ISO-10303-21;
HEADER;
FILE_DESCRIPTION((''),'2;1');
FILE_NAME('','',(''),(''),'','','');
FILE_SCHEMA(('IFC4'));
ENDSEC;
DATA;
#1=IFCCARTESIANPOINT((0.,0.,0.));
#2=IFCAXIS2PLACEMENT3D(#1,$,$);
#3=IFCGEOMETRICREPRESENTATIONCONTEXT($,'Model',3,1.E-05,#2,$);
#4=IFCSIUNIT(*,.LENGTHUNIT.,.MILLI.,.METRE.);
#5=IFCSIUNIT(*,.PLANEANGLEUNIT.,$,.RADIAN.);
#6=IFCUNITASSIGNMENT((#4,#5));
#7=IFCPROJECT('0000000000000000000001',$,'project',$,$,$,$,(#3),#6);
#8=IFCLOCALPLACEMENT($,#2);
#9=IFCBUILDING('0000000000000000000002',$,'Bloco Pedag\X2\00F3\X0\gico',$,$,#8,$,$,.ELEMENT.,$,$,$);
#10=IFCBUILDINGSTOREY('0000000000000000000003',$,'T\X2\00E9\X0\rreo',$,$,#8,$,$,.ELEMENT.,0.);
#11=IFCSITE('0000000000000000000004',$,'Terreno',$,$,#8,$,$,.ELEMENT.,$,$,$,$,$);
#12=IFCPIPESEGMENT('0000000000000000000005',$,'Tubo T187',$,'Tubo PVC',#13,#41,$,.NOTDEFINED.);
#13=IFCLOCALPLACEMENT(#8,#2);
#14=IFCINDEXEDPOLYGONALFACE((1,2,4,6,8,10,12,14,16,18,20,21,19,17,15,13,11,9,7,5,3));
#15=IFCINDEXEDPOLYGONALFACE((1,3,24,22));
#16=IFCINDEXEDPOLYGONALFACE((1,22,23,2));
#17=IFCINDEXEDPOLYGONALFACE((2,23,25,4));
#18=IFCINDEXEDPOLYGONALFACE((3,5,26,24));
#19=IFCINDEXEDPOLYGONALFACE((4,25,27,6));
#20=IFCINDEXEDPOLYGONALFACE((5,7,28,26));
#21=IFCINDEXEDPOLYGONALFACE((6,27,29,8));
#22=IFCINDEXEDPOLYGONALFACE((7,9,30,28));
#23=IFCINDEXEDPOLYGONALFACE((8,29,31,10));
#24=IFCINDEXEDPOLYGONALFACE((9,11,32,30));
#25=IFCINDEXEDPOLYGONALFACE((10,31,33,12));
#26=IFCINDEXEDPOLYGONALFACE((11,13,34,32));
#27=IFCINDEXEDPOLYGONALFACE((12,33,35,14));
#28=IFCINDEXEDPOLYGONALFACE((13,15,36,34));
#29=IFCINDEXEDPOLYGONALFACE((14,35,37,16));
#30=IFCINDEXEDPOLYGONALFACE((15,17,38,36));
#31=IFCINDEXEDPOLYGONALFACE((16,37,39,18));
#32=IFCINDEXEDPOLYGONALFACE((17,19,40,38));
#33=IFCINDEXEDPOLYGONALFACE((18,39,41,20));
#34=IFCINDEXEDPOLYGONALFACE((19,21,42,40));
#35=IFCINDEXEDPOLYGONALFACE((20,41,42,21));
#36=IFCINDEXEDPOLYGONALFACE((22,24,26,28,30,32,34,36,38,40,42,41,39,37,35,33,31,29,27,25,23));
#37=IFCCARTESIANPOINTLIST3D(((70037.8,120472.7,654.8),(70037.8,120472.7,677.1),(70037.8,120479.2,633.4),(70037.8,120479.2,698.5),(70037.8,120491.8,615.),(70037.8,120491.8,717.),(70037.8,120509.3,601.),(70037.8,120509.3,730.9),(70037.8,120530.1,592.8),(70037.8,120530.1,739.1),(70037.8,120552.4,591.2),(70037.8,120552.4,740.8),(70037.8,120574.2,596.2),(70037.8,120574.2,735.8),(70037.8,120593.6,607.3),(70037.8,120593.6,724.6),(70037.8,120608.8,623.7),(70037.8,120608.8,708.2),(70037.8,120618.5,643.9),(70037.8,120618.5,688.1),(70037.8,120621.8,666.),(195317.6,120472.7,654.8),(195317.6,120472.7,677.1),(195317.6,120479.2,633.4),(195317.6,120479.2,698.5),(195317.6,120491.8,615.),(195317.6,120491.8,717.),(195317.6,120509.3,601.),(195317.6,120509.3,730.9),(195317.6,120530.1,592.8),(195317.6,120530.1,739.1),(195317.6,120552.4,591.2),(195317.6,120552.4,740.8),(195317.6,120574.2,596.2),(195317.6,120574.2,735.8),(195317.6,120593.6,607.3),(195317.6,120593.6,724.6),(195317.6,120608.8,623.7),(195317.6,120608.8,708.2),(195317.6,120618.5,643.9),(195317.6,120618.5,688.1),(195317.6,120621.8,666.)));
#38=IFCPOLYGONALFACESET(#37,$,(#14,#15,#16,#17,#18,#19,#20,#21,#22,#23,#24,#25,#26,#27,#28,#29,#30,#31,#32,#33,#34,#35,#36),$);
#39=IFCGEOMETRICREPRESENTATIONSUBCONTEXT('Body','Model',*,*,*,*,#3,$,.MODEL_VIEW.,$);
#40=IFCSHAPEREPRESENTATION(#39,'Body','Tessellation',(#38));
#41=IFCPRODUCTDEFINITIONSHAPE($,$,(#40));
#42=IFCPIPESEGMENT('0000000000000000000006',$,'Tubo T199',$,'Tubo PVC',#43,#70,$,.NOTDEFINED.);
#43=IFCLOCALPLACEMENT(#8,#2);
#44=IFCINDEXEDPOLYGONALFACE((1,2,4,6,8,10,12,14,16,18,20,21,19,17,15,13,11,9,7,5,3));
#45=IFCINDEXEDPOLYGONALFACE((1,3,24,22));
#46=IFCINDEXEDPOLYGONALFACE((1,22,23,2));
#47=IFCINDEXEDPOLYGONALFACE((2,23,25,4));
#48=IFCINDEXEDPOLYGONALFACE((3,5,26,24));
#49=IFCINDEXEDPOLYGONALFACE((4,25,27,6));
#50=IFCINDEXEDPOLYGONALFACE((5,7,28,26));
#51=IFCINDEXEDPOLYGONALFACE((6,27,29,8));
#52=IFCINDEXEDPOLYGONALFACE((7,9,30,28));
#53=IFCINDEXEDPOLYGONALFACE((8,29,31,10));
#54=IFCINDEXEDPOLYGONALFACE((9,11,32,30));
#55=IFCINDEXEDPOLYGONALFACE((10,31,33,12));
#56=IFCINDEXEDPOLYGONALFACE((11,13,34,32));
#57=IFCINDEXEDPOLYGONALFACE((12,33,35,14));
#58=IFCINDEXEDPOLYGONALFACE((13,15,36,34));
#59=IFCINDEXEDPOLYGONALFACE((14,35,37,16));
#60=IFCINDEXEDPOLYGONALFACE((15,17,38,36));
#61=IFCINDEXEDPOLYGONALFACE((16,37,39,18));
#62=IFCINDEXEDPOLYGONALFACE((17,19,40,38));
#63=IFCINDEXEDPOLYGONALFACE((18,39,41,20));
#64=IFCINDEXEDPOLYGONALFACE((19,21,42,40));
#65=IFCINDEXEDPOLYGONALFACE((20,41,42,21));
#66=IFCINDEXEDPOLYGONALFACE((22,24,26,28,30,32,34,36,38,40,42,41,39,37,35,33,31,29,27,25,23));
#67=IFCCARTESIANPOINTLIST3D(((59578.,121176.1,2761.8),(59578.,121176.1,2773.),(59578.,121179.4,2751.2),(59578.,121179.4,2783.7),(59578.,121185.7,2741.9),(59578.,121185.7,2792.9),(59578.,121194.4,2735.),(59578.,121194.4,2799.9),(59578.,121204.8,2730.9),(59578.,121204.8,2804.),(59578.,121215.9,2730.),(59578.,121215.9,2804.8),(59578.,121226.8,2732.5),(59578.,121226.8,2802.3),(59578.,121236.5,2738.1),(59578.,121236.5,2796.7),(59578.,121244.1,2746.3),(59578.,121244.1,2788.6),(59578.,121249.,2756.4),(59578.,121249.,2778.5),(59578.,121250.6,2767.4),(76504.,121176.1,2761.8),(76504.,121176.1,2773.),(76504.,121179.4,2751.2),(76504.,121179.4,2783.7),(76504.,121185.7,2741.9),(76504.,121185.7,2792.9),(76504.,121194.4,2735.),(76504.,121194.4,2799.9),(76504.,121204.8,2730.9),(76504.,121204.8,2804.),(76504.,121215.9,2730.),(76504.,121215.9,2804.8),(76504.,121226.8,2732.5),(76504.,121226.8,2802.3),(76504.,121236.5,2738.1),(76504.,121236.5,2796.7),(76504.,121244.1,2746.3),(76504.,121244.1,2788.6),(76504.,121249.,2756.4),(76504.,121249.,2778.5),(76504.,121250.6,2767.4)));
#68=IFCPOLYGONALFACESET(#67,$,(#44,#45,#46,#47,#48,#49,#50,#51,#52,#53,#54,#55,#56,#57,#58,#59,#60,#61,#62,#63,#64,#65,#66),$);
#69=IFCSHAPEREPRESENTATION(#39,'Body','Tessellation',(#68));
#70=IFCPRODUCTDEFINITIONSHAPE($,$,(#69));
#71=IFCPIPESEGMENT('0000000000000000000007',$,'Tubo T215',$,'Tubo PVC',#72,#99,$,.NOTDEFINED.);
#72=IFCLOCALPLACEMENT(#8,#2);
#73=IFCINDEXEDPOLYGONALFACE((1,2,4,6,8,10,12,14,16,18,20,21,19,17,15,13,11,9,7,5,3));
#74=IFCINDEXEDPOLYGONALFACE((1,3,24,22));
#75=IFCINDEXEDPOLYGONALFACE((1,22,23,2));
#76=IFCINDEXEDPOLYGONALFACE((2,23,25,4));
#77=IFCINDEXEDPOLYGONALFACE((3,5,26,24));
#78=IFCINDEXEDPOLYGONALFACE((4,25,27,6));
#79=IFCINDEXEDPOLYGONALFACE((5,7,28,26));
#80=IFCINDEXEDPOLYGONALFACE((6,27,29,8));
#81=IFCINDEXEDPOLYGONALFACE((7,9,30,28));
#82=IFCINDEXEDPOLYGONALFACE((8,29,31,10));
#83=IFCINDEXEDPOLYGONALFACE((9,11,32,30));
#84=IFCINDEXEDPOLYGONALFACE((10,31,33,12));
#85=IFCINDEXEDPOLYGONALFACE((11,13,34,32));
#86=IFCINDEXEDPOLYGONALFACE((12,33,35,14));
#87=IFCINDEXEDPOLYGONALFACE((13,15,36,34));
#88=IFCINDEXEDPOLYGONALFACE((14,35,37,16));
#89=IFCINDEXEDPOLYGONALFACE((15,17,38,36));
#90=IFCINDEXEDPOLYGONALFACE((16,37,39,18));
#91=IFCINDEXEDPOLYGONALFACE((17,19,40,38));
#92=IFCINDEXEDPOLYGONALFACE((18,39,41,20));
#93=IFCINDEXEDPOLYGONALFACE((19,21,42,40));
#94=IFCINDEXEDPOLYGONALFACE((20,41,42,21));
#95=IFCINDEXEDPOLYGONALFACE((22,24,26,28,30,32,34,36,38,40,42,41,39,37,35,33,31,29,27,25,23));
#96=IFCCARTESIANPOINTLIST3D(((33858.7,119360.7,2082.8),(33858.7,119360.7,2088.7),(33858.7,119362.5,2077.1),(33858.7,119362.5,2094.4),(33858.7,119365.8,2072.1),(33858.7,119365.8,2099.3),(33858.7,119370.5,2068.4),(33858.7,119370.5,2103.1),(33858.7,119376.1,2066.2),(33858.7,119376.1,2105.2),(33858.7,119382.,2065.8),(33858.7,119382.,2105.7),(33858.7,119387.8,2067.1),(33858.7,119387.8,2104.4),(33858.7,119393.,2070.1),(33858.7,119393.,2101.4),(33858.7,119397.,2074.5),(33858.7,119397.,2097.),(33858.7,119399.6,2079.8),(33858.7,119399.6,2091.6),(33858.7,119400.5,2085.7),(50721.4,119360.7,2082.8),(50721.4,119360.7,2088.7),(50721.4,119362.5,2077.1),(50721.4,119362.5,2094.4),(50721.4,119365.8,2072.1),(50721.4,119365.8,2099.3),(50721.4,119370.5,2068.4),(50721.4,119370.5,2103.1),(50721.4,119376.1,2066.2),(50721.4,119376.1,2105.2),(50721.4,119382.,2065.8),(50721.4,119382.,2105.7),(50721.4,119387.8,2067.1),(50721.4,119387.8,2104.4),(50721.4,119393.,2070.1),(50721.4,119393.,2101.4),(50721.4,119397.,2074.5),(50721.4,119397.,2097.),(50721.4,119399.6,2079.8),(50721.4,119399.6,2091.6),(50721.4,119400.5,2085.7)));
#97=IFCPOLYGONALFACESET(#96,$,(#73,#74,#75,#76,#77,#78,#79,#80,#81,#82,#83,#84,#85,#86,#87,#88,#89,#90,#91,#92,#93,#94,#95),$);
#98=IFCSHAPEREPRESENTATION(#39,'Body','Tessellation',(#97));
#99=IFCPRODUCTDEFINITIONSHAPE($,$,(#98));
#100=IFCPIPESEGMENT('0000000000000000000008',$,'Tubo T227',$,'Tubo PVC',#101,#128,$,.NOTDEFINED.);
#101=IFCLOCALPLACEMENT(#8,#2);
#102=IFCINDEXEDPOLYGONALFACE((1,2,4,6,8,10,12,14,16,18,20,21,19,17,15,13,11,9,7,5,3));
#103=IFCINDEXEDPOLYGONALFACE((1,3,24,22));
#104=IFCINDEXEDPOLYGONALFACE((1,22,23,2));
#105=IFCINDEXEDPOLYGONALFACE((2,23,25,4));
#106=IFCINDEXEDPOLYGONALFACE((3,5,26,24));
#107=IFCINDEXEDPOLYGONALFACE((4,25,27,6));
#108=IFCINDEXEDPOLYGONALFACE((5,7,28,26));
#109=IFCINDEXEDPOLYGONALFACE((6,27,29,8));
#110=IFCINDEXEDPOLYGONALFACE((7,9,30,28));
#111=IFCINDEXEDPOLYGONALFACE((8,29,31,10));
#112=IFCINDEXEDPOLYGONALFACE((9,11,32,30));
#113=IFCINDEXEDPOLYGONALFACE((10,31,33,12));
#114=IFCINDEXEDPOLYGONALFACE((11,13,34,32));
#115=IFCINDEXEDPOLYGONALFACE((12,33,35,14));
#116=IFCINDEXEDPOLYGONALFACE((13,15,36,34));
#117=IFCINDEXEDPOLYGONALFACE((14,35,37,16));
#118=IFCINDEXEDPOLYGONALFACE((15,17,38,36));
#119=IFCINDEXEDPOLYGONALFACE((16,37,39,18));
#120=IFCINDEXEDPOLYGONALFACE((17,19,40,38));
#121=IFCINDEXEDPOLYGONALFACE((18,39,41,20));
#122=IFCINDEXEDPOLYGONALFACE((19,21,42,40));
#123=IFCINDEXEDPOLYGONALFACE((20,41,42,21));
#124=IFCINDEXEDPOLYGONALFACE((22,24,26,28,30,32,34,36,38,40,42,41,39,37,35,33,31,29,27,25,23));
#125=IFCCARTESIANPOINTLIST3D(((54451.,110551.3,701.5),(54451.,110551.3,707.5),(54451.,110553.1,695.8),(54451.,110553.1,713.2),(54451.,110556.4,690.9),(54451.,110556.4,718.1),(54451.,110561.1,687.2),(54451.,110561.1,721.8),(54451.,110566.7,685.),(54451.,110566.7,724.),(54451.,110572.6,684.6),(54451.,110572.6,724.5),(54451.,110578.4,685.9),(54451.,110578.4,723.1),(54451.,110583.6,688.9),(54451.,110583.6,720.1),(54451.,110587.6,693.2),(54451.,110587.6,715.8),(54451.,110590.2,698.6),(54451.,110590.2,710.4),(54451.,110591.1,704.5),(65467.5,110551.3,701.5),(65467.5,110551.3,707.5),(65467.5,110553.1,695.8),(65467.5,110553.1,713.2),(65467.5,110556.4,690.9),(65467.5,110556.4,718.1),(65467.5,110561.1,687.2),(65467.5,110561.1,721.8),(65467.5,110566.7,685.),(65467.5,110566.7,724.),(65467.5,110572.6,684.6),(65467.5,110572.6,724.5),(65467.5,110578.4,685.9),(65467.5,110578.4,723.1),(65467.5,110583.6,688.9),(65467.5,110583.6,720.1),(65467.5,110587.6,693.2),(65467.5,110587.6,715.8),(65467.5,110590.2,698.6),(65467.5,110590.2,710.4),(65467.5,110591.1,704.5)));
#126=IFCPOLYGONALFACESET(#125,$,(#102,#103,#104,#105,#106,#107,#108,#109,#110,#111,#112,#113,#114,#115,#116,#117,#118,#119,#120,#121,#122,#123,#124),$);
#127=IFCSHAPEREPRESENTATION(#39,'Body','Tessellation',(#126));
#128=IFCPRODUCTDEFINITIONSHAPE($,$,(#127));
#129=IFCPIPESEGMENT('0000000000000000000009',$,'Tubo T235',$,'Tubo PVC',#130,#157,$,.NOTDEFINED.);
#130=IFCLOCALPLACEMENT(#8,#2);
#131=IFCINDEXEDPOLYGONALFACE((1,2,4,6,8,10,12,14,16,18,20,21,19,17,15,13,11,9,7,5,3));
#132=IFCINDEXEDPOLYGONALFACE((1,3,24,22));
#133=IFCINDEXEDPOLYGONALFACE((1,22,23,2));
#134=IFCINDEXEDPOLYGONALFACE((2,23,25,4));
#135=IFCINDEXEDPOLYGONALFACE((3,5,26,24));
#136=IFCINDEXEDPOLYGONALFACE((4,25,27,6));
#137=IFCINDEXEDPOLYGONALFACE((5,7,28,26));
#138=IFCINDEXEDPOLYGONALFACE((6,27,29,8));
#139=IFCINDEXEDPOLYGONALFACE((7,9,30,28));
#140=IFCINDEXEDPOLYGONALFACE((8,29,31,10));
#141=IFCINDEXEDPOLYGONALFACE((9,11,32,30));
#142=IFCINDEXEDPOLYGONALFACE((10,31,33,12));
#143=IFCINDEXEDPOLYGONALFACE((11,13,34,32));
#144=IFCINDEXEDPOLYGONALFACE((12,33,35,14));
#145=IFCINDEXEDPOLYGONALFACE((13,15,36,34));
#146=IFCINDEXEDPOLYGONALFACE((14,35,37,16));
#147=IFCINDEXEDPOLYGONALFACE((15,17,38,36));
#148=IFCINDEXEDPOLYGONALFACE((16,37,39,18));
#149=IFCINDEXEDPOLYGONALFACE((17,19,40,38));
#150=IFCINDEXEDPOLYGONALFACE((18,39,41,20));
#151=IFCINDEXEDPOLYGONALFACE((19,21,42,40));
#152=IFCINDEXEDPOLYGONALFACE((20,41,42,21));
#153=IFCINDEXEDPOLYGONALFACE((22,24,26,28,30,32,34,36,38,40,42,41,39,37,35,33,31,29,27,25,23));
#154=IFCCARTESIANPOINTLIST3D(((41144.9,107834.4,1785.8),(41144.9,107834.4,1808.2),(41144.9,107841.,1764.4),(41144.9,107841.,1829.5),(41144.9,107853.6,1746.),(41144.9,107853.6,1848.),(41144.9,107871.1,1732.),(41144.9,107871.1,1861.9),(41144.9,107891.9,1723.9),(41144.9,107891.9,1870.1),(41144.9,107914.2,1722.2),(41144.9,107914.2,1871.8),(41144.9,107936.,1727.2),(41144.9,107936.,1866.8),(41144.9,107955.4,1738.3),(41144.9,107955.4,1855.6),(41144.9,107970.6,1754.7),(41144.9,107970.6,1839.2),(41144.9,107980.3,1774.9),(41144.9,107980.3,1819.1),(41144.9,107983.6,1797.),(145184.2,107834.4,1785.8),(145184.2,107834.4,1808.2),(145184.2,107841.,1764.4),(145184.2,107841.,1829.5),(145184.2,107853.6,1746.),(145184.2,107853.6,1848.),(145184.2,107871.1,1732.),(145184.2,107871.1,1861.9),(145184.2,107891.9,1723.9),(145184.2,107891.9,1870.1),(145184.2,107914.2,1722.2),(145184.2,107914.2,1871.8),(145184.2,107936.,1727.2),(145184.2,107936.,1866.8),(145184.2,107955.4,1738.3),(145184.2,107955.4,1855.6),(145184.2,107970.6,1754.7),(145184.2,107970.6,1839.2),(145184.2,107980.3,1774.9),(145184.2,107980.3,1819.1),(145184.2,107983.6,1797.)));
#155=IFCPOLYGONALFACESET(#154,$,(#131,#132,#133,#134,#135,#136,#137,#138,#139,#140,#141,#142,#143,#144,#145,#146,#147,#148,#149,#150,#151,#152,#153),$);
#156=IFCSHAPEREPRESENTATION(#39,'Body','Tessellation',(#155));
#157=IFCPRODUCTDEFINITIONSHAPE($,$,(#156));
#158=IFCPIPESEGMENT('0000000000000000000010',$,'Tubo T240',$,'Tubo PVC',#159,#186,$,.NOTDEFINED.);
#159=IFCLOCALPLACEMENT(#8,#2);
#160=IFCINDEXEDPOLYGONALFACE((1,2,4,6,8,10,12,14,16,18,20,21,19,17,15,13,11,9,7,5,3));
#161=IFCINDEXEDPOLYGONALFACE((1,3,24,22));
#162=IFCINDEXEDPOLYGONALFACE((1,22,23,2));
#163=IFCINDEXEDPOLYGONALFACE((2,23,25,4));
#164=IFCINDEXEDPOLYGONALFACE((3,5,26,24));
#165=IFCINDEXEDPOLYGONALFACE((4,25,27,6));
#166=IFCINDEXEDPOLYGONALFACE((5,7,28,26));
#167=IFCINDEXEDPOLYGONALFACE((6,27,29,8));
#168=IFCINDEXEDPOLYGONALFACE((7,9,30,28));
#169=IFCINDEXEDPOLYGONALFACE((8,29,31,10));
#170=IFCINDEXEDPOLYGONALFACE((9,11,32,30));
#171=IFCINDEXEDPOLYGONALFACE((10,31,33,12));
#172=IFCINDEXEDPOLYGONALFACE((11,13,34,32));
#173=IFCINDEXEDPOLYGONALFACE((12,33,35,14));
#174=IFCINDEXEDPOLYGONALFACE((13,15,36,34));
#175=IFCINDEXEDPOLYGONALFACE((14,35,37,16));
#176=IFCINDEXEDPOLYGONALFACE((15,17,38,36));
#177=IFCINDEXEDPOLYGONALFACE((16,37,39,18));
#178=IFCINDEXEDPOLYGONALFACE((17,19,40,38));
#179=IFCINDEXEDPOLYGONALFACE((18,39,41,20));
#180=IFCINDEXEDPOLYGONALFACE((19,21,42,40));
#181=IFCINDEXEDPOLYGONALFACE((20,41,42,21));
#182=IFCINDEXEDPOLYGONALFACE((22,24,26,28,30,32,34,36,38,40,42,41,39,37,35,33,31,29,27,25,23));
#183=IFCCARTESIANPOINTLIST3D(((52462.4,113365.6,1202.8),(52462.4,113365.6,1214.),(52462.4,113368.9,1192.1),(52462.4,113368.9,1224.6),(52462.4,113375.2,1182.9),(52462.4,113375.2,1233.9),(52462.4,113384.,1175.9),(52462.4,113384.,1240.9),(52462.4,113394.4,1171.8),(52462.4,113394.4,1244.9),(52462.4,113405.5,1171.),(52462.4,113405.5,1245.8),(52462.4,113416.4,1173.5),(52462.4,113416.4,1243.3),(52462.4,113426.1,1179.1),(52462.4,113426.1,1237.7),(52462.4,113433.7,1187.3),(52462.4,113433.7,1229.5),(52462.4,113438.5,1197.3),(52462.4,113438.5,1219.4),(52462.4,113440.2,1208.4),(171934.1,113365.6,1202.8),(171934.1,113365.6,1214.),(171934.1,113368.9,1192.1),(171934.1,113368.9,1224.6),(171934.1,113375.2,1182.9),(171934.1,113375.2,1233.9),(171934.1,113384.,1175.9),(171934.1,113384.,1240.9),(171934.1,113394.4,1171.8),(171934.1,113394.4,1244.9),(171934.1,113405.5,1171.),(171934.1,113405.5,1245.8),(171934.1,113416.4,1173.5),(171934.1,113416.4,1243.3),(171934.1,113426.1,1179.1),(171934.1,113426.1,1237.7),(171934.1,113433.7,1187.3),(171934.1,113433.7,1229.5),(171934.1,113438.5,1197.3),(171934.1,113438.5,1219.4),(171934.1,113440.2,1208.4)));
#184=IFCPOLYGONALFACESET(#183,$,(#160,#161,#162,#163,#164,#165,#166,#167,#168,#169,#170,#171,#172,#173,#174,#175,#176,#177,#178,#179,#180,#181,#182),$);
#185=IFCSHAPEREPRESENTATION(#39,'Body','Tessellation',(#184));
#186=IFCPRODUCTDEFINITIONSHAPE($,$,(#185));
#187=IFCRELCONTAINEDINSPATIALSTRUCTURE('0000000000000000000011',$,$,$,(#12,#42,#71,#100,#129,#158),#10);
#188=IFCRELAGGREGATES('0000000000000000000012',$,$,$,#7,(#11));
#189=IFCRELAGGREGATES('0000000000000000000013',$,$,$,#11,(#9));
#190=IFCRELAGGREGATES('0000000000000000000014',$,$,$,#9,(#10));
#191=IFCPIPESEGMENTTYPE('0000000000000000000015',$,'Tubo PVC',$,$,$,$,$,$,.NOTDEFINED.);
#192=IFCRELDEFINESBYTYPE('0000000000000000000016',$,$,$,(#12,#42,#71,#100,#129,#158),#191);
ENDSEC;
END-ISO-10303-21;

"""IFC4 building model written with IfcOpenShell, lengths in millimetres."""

from ifc_helpers import new_model, si_unit, frame, origin, origin_2d, place, context, subcontext, project, spatial, circle, extrude, type_object, element, save


model = new_model("IFC4")

# Units and contexts
model_context = context("Model", 3, precision=1e-05, world=origin())
body_context = subcontext(model_context, "Body", "Model", "MODEL_VIEW")
ifc_project = project(units=[si_unit("LENGTHUNIT", "METRE", prefix="MILLI"), si_unit("PLANEANGLEUNIT", "RADIAN")], contexts=[model_context])

# Site, building, storey
placement = place(None, origin())
site = spatial("IfcSite", under=ifc_project, at=placement, Name="Terreno", CompositionType="ELEMENT")
building = spatial("IfcBuilding", under=site, at=placement, Name="Bloco Pedagógico", CompositionType="ELEMENT")
storey = spatial("IfcBuildingStorey", under=building, at=placement, Name="Térreo", CompositionType="ELEMENT", Elevation=0.0)

# Pipe segments
pipe_segment_type = type_object("IfcPipeSegmentType", Name="Tubo PVC", PredefinedType="NOTDEFINED")
pipe_segment_1_placement = place(None, frame((70037.8, 120546.8, 666.0), z_axis=(1.0, 0.0, 0.0), x_axis=(0.0, 1.0, 0.0)))
element("IfcPipeSegment", 1, at=pipe_segment_1_placement, inside=storey, type_object=pipe_segment_type, Name="Tubo T187", ObjectType="Tubo PVC", PredefinedType="NOTDEFINED", context=body_context, shape_type="SweptSolid", body=[
    extrude(circle(Radius=75.0, at=origin_2d()), None, (0.0, 0.0, 1.0), 125279.8),
])
pipe_segment_2_placement = place(None, frame((59578.0, 121213.1, 2767.4), z_axis=(1.0, 0.0, 0.0), x_axis=(0.0, 1.0, 0.0)))
element("IfcPipeSegment", 2, at=pipe_segment_2_placement, inside=storey, type_object=pipe_segment_type, Name="Tubo T199", ObjectType="Tubo PVC", PredefinedType="NOTDEFINED", context=body_context, shape_type="SweptSolid", body=[
    extrude(circle(Radius=37.5, at=origin_2d()), None, (0.0, 0.0, 1.0), 16926.0),
])
pipe_segment_3_placement = place(None, frame((33858.7, 119380.5, 2085.7), z_axis=(1.0, 0.0, 0.0), x_axis=(0.0, 1.0, 0.0)))
element("IfcPipeSegment", 3, at=pipe_segment_3_placement, inside=storey, type_object=pipe_segment_type, Name="Tubo T215", ObjectType="Tubo PVC", PredefinedType="NOTDEFINED", context=body_context, shape_type="SweptSolid", body=[
    extrude(circle(Radius=20.0, at=origin_2d()), None, (0.0, 0.0, 1.0), 16862.7),
])
pipe_segment_4_placement = place(None, frame((54451.0, 110571.1, 704.5), z_axis=(1.0, 0.0, 0.0), x_axis=(0.0, 1.0, 0.0)))
element("IfcPipeSegment", 4, at=pipe_segment_4_placement, inside=storey, type_object=pipe_segment_type, Name="Tubo T227", ObjectType="Tubo PVC", PredefinedType="NOTDEFINED", context=body_context, shape_type="SweptSolid", body=[
    extrude(circle(Radius=20.0, at=origin_2d()), None, (0.0, 0.0, 1.0), 11016.5),
])
pipe_segment_5_placement = place(None, frame((41144.9, 107908.6, 1797.0), z_axis=(1.0, 0.0, 0.0), x_axis=(0.0, 1.0, 0.0)))
element("IfcPipeSegment", 5, at=pipe_segment_5_placement, inside=storey, type_object=pipe_segment_type, Name="Tubo T235", ObjectType="Tubo PVC", PredefinedType="NOTDEFINED", context=body_context, shape_type="SweptSolid", body=[
    extrude(circle(Radius=75.0, at=origin_2d()), None, (0.0, 0.0, 1.0), 104039.4),
])
pipe_segment_6_placement = place(None, frame((52462.4, 113402.7, 1208.4), z_axis=(1.0, 0.0, 0.0), x_axis=(0.0, 1.0, 0.0)))
element("IfcPipeSegment", 6, at=pipe_segment_6_placement, inside=storey, type_object=pipe_segment_type, Name="Tubo T240", ObjectType="Tubo PVC", PredefinedType="NOTDEFINED", context=body_context, shape_type="SweptSolid", body=[
    extrude(circle(Radius=37.5, at=origin_2d()), None, (0.0, 0.0, 1.0), 119471.8),
])

save(model, "model.ifc")
